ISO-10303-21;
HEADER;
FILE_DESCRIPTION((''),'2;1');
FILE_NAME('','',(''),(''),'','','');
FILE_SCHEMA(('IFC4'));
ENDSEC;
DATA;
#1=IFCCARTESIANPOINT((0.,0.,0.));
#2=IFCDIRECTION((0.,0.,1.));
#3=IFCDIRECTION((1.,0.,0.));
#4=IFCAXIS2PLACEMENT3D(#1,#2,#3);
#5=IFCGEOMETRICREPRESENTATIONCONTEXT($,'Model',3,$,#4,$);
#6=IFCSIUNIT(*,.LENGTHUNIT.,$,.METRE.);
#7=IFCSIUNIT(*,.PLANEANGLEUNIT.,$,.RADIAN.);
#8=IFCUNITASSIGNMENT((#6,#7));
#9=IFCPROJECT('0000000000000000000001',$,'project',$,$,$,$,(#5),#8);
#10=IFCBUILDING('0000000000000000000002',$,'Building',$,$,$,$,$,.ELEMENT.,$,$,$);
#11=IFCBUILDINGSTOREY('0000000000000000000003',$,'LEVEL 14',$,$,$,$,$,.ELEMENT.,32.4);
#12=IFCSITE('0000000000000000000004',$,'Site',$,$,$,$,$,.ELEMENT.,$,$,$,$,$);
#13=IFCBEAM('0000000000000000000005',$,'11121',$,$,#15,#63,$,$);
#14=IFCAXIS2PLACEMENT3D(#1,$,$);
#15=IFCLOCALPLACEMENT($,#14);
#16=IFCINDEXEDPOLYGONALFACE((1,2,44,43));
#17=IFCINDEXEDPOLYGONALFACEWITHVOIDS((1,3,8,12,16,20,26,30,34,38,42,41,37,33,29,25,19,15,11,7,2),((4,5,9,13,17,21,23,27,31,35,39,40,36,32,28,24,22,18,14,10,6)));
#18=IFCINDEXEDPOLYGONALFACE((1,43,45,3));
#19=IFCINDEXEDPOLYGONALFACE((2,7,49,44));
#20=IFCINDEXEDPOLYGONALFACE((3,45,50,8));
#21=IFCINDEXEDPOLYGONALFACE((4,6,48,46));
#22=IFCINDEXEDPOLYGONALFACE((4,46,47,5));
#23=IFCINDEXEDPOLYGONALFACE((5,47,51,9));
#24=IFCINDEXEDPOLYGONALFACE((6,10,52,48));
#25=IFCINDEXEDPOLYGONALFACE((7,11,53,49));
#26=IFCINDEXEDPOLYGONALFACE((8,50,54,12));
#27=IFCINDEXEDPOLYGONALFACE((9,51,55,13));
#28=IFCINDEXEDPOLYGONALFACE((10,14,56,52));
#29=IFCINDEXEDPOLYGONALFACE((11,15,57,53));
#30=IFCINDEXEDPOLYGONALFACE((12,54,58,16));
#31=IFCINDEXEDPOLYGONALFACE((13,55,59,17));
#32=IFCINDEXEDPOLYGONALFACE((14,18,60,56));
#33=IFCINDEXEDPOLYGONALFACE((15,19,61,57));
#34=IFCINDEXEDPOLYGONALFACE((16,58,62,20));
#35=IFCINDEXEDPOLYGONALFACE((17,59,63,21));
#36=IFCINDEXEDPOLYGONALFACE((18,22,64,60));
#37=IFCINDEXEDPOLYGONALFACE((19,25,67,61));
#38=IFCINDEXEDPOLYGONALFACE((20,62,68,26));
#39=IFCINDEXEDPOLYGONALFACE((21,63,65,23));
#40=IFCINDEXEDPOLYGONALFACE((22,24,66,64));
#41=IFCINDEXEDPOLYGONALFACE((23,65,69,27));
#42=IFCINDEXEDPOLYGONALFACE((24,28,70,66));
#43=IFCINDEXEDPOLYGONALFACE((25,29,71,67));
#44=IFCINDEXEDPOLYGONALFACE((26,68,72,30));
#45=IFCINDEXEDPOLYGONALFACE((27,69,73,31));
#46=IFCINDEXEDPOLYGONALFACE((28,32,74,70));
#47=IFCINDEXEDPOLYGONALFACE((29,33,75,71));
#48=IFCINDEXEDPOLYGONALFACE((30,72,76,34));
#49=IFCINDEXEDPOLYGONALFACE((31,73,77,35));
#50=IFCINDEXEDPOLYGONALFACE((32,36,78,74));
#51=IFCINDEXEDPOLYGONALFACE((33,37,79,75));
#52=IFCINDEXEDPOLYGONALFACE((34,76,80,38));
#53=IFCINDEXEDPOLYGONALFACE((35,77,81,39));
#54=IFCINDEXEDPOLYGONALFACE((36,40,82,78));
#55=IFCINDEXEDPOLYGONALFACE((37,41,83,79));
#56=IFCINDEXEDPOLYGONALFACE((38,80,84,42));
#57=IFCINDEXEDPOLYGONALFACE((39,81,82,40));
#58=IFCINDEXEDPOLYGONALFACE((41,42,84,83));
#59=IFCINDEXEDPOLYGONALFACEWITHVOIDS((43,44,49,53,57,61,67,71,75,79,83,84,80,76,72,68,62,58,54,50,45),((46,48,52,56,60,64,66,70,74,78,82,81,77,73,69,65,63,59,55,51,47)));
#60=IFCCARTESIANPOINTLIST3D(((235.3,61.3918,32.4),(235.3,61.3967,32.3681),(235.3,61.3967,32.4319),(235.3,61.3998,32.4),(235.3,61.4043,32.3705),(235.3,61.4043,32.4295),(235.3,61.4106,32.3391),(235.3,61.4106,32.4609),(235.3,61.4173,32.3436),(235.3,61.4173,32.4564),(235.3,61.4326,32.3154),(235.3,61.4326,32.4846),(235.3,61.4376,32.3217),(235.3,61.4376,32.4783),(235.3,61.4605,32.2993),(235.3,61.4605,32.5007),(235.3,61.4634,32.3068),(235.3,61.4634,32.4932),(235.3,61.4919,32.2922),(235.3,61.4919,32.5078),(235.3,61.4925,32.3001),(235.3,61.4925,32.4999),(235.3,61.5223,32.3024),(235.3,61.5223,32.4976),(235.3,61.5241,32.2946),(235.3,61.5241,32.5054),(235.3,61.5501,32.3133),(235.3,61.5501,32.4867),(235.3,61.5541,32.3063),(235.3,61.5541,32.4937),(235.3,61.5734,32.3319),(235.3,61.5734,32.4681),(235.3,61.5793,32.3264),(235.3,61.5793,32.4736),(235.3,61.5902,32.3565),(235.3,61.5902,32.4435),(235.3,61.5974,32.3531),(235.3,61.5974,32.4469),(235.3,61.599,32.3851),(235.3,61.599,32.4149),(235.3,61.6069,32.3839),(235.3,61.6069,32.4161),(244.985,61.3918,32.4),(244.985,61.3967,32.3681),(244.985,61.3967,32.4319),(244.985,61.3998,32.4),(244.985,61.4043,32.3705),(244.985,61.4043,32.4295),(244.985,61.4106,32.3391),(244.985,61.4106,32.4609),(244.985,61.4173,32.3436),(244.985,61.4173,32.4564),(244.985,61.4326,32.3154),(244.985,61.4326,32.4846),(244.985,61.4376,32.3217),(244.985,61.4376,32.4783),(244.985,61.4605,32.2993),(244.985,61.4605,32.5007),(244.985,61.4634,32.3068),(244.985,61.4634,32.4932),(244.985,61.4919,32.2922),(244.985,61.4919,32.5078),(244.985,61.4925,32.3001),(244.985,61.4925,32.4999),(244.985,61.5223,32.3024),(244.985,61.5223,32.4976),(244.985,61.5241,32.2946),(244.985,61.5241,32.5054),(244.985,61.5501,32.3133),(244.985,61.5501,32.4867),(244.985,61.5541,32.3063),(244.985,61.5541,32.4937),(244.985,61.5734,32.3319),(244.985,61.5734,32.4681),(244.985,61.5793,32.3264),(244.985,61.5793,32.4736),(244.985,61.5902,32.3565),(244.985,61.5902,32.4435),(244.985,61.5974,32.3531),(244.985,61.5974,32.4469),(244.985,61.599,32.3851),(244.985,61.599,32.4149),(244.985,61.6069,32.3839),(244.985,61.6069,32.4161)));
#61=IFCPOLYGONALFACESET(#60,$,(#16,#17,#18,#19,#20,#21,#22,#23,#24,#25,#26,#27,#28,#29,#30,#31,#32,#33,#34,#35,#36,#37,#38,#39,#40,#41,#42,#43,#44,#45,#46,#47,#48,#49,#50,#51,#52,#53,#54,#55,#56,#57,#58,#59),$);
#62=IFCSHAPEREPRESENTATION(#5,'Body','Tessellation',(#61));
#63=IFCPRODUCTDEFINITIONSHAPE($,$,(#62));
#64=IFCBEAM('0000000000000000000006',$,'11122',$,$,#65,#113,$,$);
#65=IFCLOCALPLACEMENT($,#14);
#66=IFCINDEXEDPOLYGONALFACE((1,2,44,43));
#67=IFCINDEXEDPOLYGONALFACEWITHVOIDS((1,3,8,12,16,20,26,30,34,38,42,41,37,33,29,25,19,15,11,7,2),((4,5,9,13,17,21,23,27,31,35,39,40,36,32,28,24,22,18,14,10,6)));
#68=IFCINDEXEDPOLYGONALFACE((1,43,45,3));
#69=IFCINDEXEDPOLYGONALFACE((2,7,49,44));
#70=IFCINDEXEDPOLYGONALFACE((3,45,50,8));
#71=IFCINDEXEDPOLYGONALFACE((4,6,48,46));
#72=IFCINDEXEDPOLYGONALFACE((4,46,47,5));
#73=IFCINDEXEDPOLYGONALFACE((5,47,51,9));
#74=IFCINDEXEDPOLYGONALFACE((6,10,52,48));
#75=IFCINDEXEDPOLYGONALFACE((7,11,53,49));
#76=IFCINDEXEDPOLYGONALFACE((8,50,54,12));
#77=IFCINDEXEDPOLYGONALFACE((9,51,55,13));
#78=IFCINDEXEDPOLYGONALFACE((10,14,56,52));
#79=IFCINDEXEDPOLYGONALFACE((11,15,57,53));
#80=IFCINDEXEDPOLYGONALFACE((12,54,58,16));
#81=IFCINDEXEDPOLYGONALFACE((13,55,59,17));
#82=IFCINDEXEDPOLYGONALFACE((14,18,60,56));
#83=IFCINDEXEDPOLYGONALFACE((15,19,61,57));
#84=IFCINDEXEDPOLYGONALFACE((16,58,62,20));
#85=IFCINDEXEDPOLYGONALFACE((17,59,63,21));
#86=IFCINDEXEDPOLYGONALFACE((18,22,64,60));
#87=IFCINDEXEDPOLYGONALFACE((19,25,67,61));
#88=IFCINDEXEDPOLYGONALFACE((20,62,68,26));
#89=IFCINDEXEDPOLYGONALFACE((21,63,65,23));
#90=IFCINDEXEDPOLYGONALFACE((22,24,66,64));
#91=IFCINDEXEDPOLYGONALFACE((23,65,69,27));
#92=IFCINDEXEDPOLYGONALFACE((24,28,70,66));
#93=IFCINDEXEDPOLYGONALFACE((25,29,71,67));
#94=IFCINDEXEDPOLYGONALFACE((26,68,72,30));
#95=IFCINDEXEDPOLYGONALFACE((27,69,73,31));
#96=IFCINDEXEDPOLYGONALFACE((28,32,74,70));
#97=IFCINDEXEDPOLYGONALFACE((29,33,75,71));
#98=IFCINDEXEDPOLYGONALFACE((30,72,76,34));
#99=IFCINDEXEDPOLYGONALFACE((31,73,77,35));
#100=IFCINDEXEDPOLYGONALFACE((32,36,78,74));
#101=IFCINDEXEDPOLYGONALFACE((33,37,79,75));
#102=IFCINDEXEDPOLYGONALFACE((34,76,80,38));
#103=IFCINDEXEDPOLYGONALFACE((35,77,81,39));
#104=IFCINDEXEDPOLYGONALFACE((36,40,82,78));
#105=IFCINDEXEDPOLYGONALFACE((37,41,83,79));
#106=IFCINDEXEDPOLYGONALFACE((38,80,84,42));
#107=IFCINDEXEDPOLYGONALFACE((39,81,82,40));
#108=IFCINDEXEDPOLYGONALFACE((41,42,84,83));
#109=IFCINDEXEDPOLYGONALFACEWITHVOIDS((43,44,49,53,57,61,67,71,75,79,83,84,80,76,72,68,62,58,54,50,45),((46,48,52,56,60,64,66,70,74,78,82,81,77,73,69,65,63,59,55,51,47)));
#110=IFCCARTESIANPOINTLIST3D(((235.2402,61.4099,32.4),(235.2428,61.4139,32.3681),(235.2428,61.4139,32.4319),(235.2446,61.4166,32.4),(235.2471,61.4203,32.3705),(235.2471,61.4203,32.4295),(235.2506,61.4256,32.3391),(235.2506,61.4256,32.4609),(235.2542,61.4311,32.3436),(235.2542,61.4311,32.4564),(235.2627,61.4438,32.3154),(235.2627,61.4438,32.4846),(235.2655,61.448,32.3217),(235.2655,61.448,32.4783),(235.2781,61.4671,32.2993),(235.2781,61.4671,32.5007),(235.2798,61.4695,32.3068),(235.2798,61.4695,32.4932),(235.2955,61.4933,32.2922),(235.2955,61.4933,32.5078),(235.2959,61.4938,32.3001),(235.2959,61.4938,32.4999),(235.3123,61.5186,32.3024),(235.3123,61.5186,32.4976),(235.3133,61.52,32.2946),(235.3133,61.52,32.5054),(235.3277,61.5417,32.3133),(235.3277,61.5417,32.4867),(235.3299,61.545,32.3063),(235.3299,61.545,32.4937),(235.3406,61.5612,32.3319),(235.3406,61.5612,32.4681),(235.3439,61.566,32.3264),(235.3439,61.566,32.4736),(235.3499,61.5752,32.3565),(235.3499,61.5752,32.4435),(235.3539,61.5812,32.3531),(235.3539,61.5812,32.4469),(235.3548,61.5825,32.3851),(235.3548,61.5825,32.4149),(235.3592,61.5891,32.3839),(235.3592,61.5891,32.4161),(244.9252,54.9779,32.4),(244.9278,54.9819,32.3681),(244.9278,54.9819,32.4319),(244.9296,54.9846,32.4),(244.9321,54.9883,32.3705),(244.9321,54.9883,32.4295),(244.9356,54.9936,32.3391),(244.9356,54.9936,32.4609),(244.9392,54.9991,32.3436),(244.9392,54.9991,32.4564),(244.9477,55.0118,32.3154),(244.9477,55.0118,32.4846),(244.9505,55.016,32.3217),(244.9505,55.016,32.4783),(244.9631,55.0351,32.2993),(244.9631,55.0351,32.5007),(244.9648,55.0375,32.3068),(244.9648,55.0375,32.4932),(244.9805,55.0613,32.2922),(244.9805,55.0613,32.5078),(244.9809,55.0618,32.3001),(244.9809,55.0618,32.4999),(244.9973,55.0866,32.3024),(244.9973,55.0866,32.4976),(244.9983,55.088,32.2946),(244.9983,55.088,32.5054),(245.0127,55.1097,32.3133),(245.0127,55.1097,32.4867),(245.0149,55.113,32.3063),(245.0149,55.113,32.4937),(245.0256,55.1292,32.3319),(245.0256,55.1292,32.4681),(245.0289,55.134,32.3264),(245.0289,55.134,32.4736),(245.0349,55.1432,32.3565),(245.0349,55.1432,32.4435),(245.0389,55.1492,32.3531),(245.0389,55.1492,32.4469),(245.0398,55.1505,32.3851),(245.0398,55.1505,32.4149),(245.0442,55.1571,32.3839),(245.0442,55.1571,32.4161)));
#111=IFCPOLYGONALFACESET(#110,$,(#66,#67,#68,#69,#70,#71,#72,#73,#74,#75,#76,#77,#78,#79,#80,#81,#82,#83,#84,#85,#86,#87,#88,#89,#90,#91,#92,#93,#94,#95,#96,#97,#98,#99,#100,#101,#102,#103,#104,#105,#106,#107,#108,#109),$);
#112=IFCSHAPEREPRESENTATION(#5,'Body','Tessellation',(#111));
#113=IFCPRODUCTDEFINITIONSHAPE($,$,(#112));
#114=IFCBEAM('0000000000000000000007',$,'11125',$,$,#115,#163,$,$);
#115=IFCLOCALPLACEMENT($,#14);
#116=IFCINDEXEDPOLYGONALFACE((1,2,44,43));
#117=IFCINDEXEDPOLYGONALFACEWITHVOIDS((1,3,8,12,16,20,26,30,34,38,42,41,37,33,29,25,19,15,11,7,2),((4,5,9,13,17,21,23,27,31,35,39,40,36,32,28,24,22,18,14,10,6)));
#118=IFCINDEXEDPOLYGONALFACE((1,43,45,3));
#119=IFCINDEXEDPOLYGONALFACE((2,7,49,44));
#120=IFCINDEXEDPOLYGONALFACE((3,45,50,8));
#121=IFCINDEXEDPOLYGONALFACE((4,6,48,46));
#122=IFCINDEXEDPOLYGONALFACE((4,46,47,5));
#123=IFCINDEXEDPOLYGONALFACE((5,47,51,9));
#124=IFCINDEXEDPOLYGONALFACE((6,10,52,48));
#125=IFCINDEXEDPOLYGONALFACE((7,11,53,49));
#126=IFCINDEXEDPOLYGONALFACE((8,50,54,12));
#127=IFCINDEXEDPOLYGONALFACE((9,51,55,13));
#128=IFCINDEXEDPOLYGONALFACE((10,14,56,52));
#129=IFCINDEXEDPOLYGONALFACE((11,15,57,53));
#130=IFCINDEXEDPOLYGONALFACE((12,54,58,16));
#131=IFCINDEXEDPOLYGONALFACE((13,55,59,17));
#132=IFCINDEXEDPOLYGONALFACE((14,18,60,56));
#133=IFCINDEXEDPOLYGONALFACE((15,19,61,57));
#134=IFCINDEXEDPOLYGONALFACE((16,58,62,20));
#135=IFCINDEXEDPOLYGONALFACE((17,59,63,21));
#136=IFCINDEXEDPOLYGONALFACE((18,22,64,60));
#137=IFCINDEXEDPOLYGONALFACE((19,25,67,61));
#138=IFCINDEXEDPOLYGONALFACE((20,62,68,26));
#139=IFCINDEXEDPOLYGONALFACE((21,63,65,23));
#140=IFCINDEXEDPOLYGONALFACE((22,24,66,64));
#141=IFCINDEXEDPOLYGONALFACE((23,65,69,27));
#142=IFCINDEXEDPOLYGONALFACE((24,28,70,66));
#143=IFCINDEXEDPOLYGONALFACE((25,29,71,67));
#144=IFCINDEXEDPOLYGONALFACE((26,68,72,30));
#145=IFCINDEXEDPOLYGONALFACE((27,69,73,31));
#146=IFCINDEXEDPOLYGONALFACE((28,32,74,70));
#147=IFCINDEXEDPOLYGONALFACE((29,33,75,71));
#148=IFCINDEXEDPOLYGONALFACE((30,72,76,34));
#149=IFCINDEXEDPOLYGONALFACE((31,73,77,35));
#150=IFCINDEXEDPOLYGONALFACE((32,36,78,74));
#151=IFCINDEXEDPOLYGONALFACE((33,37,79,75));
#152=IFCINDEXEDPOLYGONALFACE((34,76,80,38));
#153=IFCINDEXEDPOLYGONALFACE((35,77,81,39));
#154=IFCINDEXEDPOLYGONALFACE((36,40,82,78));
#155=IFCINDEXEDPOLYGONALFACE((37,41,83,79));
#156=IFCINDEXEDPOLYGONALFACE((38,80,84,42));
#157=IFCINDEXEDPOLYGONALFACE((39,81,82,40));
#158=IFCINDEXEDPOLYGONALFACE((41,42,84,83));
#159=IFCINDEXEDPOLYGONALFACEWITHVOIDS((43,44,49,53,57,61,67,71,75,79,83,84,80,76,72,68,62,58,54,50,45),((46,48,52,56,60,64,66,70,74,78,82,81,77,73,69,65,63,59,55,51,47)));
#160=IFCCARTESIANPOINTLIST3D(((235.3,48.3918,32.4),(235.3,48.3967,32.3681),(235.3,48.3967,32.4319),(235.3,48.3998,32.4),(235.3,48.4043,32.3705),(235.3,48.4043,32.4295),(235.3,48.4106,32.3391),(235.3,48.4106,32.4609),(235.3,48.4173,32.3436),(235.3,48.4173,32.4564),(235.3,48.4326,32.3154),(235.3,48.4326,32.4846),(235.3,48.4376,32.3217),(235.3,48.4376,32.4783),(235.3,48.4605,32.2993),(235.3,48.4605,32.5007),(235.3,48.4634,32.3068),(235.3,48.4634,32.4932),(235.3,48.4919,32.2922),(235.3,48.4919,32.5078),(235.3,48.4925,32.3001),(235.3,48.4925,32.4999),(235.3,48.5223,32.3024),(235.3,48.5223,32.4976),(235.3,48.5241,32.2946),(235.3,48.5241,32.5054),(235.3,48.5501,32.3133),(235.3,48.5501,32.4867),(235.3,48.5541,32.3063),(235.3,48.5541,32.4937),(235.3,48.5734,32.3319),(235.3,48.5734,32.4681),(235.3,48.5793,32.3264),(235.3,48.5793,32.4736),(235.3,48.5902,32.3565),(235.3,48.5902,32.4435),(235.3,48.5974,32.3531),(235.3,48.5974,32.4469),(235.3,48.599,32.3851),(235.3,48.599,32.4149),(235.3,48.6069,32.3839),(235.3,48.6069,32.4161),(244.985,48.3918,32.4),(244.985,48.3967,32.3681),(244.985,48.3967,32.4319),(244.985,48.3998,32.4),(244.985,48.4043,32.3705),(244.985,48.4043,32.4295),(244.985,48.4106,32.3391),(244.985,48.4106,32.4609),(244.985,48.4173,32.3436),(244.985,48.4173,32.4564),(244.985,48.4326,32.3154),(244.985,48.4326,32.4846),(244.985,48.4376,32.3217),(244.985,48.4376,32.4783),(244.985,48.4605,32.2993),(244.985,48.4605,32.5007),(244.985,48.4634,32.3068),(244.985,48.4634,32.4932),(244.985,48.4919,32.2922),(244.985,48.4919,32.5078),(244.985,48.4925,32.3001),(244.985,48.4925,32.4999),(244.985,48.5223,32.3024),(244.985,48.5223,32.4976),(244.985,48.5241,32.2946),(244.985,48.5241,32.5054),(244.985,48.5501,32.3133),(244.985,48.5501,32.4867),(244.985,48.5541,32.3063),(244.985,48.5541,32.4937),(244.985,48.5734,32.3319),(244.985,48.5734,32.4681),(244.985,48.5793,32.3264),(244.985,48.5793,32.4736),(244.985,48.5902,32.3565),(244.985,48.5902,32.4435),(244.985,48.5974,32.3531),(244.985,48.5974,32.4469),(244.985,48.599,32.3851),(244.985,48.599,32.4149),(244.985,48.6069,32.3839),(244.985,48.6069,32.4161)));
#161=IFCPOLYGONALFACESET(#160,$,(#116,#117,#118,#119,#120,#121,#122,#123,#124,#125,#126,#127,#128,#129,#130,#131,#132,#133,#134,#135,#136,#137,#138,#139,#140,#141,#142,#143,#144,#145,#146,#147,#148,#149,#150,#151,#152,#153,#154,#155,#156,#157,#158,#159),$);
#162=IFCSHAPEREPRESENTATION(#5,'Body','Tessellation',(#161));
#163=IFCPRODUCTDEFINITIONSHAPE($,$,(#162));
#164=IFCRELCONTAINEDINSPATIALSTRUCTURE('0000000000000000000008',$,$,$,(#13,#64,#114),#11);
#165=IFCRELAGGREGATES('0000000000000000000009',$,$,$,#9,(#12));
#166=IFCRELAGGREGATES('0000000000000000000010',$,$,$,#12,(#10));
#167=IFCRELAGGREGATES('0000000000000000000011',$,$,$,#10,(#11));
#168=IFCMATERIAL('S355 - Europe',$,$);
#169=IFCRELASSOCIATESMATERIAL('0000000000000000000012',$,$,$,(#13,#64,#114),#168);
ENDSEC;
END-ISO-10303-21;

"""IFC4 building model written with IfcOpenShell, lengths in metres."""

from ifc_helpers import new_model, si_unit, frame, origin_with_axes, origin_2d_with_axis, place, context, project, spatial, hollow_circle, extrude, material, material_profile, profile_set, profile_usage, element, save


model = new_model("IFC4")

# Units and contexts
model_context = context("Model", 3, world=origin_with_axes())
ifc_project = project(units=[si_unit("LENGTHUNIT", "METRE"), si_unit("PLANEANGLEUNIT", "RADIAN")], contexts=[model_context])

# Site, building, storey
site = spatial("IfcSite", under=ifc_project, Name="Site", CompositionType="ELEMENT")
building = spatial("IfcBuilding", under=site, Name="Building", CompositionType="ELEMENT")
storey = spatial("IfcBuildingStorey", under=building, Name="LEVEL 14", CompositionType="ELEMENT", Elevation=32.4)

# Shared definitions
ifc_material = material(Name="S355 - Europe")

# Beams
ifc_material_profile_1 = material_profile(ifc_material, hollow_circle(Radius=0.1081, WallThickness=0.008, at=origin_2d_with_axis()))
ifc_profile_set_1 = profile_set([ifc_material_profile_1])
ifc_profile_usage_1 = profile_usage(ifc_profile_set_1, cardinal=10)
beam_1_placement = place(None, frame((244.985, 61.5, 32.4), z_axis=(-1.0, 0.0, 0.0), x_axis=(0.0, -1.0, 0.0)))
element("IfcBeam", 1, at=beam_1_placement, inside=storey, material=ifc_profile_usage_1, Name="11121", context=model_context, shape_type="SweptSolid", body=[
    extrude(hollow_circle(Radius=0.1081, WallThickness=0.008, at=origin_2d_with_axis()), origin_with_axes(), (0.0, 0.0, 1.0), 9.685),
])
ifc_material_profile_2 = material_profile(ifc_material, hollow_circle(Radius=0.1081, WallThickness=0.008, at=origin_2d_with_axis()))
ifc_profile_set_2 = profile_set([ifc_material_profile_2])
ifc_profile_usage_2 = profile_usage(ifc_profile_set_2, cardinal=10)
beam_2_placement = place(None, frame((244.985, 55.068, 32.4), z_axis=(-0.833028, 0.553231, 0.0), x_axis=(-0.553231, -0.833028, 0.0)))
element("IfcBeam", 2, at=beam_2_placement, inside=storey, material=ifc_profile_usage_2, Name="11122", context=model_context, shape_type="SweptSolid", body=[
    extrude(hollow_circle(Radius=0.1081, WallThickness=0.008, at=origin_2d_with_axis()), origin_with_axes(), (0.0, 0.0, 1.0), 11.6263),
])
ifc_material_profile_3 = material_profile(ifc_material, hollow_circle(Radius=0.1081, WallThickness=0.008, at=origin_2d_with_axis()))
ifc_profile_set_3 = profile_set([ifc_material_profile_3])
ifc_profile_usage_3 = profile_usage(ifc_profile_set_3, cardinal=10)
beam_3_placement = place(None, frame((244.985, 48.5, 32.4), z_axis=(-1.0, 0.0, 0.0), x_axis=(0.0, -1.0, 0.0)))
element("IfcBeam", 3, at=beam_3_placement, inside=storey, material=ifc_profile_usage_3, Name="11125", context=model_context, shape_type="SweptSolid", body=[
    extrude(hollow_circle(Radius=0.1081, WallThickness=0.008, at=origin_2d_with_axis()), origin_with_axes(), (0.0, 0.0, 1.0), 9.685),
])

save(model, "model.ifc")
